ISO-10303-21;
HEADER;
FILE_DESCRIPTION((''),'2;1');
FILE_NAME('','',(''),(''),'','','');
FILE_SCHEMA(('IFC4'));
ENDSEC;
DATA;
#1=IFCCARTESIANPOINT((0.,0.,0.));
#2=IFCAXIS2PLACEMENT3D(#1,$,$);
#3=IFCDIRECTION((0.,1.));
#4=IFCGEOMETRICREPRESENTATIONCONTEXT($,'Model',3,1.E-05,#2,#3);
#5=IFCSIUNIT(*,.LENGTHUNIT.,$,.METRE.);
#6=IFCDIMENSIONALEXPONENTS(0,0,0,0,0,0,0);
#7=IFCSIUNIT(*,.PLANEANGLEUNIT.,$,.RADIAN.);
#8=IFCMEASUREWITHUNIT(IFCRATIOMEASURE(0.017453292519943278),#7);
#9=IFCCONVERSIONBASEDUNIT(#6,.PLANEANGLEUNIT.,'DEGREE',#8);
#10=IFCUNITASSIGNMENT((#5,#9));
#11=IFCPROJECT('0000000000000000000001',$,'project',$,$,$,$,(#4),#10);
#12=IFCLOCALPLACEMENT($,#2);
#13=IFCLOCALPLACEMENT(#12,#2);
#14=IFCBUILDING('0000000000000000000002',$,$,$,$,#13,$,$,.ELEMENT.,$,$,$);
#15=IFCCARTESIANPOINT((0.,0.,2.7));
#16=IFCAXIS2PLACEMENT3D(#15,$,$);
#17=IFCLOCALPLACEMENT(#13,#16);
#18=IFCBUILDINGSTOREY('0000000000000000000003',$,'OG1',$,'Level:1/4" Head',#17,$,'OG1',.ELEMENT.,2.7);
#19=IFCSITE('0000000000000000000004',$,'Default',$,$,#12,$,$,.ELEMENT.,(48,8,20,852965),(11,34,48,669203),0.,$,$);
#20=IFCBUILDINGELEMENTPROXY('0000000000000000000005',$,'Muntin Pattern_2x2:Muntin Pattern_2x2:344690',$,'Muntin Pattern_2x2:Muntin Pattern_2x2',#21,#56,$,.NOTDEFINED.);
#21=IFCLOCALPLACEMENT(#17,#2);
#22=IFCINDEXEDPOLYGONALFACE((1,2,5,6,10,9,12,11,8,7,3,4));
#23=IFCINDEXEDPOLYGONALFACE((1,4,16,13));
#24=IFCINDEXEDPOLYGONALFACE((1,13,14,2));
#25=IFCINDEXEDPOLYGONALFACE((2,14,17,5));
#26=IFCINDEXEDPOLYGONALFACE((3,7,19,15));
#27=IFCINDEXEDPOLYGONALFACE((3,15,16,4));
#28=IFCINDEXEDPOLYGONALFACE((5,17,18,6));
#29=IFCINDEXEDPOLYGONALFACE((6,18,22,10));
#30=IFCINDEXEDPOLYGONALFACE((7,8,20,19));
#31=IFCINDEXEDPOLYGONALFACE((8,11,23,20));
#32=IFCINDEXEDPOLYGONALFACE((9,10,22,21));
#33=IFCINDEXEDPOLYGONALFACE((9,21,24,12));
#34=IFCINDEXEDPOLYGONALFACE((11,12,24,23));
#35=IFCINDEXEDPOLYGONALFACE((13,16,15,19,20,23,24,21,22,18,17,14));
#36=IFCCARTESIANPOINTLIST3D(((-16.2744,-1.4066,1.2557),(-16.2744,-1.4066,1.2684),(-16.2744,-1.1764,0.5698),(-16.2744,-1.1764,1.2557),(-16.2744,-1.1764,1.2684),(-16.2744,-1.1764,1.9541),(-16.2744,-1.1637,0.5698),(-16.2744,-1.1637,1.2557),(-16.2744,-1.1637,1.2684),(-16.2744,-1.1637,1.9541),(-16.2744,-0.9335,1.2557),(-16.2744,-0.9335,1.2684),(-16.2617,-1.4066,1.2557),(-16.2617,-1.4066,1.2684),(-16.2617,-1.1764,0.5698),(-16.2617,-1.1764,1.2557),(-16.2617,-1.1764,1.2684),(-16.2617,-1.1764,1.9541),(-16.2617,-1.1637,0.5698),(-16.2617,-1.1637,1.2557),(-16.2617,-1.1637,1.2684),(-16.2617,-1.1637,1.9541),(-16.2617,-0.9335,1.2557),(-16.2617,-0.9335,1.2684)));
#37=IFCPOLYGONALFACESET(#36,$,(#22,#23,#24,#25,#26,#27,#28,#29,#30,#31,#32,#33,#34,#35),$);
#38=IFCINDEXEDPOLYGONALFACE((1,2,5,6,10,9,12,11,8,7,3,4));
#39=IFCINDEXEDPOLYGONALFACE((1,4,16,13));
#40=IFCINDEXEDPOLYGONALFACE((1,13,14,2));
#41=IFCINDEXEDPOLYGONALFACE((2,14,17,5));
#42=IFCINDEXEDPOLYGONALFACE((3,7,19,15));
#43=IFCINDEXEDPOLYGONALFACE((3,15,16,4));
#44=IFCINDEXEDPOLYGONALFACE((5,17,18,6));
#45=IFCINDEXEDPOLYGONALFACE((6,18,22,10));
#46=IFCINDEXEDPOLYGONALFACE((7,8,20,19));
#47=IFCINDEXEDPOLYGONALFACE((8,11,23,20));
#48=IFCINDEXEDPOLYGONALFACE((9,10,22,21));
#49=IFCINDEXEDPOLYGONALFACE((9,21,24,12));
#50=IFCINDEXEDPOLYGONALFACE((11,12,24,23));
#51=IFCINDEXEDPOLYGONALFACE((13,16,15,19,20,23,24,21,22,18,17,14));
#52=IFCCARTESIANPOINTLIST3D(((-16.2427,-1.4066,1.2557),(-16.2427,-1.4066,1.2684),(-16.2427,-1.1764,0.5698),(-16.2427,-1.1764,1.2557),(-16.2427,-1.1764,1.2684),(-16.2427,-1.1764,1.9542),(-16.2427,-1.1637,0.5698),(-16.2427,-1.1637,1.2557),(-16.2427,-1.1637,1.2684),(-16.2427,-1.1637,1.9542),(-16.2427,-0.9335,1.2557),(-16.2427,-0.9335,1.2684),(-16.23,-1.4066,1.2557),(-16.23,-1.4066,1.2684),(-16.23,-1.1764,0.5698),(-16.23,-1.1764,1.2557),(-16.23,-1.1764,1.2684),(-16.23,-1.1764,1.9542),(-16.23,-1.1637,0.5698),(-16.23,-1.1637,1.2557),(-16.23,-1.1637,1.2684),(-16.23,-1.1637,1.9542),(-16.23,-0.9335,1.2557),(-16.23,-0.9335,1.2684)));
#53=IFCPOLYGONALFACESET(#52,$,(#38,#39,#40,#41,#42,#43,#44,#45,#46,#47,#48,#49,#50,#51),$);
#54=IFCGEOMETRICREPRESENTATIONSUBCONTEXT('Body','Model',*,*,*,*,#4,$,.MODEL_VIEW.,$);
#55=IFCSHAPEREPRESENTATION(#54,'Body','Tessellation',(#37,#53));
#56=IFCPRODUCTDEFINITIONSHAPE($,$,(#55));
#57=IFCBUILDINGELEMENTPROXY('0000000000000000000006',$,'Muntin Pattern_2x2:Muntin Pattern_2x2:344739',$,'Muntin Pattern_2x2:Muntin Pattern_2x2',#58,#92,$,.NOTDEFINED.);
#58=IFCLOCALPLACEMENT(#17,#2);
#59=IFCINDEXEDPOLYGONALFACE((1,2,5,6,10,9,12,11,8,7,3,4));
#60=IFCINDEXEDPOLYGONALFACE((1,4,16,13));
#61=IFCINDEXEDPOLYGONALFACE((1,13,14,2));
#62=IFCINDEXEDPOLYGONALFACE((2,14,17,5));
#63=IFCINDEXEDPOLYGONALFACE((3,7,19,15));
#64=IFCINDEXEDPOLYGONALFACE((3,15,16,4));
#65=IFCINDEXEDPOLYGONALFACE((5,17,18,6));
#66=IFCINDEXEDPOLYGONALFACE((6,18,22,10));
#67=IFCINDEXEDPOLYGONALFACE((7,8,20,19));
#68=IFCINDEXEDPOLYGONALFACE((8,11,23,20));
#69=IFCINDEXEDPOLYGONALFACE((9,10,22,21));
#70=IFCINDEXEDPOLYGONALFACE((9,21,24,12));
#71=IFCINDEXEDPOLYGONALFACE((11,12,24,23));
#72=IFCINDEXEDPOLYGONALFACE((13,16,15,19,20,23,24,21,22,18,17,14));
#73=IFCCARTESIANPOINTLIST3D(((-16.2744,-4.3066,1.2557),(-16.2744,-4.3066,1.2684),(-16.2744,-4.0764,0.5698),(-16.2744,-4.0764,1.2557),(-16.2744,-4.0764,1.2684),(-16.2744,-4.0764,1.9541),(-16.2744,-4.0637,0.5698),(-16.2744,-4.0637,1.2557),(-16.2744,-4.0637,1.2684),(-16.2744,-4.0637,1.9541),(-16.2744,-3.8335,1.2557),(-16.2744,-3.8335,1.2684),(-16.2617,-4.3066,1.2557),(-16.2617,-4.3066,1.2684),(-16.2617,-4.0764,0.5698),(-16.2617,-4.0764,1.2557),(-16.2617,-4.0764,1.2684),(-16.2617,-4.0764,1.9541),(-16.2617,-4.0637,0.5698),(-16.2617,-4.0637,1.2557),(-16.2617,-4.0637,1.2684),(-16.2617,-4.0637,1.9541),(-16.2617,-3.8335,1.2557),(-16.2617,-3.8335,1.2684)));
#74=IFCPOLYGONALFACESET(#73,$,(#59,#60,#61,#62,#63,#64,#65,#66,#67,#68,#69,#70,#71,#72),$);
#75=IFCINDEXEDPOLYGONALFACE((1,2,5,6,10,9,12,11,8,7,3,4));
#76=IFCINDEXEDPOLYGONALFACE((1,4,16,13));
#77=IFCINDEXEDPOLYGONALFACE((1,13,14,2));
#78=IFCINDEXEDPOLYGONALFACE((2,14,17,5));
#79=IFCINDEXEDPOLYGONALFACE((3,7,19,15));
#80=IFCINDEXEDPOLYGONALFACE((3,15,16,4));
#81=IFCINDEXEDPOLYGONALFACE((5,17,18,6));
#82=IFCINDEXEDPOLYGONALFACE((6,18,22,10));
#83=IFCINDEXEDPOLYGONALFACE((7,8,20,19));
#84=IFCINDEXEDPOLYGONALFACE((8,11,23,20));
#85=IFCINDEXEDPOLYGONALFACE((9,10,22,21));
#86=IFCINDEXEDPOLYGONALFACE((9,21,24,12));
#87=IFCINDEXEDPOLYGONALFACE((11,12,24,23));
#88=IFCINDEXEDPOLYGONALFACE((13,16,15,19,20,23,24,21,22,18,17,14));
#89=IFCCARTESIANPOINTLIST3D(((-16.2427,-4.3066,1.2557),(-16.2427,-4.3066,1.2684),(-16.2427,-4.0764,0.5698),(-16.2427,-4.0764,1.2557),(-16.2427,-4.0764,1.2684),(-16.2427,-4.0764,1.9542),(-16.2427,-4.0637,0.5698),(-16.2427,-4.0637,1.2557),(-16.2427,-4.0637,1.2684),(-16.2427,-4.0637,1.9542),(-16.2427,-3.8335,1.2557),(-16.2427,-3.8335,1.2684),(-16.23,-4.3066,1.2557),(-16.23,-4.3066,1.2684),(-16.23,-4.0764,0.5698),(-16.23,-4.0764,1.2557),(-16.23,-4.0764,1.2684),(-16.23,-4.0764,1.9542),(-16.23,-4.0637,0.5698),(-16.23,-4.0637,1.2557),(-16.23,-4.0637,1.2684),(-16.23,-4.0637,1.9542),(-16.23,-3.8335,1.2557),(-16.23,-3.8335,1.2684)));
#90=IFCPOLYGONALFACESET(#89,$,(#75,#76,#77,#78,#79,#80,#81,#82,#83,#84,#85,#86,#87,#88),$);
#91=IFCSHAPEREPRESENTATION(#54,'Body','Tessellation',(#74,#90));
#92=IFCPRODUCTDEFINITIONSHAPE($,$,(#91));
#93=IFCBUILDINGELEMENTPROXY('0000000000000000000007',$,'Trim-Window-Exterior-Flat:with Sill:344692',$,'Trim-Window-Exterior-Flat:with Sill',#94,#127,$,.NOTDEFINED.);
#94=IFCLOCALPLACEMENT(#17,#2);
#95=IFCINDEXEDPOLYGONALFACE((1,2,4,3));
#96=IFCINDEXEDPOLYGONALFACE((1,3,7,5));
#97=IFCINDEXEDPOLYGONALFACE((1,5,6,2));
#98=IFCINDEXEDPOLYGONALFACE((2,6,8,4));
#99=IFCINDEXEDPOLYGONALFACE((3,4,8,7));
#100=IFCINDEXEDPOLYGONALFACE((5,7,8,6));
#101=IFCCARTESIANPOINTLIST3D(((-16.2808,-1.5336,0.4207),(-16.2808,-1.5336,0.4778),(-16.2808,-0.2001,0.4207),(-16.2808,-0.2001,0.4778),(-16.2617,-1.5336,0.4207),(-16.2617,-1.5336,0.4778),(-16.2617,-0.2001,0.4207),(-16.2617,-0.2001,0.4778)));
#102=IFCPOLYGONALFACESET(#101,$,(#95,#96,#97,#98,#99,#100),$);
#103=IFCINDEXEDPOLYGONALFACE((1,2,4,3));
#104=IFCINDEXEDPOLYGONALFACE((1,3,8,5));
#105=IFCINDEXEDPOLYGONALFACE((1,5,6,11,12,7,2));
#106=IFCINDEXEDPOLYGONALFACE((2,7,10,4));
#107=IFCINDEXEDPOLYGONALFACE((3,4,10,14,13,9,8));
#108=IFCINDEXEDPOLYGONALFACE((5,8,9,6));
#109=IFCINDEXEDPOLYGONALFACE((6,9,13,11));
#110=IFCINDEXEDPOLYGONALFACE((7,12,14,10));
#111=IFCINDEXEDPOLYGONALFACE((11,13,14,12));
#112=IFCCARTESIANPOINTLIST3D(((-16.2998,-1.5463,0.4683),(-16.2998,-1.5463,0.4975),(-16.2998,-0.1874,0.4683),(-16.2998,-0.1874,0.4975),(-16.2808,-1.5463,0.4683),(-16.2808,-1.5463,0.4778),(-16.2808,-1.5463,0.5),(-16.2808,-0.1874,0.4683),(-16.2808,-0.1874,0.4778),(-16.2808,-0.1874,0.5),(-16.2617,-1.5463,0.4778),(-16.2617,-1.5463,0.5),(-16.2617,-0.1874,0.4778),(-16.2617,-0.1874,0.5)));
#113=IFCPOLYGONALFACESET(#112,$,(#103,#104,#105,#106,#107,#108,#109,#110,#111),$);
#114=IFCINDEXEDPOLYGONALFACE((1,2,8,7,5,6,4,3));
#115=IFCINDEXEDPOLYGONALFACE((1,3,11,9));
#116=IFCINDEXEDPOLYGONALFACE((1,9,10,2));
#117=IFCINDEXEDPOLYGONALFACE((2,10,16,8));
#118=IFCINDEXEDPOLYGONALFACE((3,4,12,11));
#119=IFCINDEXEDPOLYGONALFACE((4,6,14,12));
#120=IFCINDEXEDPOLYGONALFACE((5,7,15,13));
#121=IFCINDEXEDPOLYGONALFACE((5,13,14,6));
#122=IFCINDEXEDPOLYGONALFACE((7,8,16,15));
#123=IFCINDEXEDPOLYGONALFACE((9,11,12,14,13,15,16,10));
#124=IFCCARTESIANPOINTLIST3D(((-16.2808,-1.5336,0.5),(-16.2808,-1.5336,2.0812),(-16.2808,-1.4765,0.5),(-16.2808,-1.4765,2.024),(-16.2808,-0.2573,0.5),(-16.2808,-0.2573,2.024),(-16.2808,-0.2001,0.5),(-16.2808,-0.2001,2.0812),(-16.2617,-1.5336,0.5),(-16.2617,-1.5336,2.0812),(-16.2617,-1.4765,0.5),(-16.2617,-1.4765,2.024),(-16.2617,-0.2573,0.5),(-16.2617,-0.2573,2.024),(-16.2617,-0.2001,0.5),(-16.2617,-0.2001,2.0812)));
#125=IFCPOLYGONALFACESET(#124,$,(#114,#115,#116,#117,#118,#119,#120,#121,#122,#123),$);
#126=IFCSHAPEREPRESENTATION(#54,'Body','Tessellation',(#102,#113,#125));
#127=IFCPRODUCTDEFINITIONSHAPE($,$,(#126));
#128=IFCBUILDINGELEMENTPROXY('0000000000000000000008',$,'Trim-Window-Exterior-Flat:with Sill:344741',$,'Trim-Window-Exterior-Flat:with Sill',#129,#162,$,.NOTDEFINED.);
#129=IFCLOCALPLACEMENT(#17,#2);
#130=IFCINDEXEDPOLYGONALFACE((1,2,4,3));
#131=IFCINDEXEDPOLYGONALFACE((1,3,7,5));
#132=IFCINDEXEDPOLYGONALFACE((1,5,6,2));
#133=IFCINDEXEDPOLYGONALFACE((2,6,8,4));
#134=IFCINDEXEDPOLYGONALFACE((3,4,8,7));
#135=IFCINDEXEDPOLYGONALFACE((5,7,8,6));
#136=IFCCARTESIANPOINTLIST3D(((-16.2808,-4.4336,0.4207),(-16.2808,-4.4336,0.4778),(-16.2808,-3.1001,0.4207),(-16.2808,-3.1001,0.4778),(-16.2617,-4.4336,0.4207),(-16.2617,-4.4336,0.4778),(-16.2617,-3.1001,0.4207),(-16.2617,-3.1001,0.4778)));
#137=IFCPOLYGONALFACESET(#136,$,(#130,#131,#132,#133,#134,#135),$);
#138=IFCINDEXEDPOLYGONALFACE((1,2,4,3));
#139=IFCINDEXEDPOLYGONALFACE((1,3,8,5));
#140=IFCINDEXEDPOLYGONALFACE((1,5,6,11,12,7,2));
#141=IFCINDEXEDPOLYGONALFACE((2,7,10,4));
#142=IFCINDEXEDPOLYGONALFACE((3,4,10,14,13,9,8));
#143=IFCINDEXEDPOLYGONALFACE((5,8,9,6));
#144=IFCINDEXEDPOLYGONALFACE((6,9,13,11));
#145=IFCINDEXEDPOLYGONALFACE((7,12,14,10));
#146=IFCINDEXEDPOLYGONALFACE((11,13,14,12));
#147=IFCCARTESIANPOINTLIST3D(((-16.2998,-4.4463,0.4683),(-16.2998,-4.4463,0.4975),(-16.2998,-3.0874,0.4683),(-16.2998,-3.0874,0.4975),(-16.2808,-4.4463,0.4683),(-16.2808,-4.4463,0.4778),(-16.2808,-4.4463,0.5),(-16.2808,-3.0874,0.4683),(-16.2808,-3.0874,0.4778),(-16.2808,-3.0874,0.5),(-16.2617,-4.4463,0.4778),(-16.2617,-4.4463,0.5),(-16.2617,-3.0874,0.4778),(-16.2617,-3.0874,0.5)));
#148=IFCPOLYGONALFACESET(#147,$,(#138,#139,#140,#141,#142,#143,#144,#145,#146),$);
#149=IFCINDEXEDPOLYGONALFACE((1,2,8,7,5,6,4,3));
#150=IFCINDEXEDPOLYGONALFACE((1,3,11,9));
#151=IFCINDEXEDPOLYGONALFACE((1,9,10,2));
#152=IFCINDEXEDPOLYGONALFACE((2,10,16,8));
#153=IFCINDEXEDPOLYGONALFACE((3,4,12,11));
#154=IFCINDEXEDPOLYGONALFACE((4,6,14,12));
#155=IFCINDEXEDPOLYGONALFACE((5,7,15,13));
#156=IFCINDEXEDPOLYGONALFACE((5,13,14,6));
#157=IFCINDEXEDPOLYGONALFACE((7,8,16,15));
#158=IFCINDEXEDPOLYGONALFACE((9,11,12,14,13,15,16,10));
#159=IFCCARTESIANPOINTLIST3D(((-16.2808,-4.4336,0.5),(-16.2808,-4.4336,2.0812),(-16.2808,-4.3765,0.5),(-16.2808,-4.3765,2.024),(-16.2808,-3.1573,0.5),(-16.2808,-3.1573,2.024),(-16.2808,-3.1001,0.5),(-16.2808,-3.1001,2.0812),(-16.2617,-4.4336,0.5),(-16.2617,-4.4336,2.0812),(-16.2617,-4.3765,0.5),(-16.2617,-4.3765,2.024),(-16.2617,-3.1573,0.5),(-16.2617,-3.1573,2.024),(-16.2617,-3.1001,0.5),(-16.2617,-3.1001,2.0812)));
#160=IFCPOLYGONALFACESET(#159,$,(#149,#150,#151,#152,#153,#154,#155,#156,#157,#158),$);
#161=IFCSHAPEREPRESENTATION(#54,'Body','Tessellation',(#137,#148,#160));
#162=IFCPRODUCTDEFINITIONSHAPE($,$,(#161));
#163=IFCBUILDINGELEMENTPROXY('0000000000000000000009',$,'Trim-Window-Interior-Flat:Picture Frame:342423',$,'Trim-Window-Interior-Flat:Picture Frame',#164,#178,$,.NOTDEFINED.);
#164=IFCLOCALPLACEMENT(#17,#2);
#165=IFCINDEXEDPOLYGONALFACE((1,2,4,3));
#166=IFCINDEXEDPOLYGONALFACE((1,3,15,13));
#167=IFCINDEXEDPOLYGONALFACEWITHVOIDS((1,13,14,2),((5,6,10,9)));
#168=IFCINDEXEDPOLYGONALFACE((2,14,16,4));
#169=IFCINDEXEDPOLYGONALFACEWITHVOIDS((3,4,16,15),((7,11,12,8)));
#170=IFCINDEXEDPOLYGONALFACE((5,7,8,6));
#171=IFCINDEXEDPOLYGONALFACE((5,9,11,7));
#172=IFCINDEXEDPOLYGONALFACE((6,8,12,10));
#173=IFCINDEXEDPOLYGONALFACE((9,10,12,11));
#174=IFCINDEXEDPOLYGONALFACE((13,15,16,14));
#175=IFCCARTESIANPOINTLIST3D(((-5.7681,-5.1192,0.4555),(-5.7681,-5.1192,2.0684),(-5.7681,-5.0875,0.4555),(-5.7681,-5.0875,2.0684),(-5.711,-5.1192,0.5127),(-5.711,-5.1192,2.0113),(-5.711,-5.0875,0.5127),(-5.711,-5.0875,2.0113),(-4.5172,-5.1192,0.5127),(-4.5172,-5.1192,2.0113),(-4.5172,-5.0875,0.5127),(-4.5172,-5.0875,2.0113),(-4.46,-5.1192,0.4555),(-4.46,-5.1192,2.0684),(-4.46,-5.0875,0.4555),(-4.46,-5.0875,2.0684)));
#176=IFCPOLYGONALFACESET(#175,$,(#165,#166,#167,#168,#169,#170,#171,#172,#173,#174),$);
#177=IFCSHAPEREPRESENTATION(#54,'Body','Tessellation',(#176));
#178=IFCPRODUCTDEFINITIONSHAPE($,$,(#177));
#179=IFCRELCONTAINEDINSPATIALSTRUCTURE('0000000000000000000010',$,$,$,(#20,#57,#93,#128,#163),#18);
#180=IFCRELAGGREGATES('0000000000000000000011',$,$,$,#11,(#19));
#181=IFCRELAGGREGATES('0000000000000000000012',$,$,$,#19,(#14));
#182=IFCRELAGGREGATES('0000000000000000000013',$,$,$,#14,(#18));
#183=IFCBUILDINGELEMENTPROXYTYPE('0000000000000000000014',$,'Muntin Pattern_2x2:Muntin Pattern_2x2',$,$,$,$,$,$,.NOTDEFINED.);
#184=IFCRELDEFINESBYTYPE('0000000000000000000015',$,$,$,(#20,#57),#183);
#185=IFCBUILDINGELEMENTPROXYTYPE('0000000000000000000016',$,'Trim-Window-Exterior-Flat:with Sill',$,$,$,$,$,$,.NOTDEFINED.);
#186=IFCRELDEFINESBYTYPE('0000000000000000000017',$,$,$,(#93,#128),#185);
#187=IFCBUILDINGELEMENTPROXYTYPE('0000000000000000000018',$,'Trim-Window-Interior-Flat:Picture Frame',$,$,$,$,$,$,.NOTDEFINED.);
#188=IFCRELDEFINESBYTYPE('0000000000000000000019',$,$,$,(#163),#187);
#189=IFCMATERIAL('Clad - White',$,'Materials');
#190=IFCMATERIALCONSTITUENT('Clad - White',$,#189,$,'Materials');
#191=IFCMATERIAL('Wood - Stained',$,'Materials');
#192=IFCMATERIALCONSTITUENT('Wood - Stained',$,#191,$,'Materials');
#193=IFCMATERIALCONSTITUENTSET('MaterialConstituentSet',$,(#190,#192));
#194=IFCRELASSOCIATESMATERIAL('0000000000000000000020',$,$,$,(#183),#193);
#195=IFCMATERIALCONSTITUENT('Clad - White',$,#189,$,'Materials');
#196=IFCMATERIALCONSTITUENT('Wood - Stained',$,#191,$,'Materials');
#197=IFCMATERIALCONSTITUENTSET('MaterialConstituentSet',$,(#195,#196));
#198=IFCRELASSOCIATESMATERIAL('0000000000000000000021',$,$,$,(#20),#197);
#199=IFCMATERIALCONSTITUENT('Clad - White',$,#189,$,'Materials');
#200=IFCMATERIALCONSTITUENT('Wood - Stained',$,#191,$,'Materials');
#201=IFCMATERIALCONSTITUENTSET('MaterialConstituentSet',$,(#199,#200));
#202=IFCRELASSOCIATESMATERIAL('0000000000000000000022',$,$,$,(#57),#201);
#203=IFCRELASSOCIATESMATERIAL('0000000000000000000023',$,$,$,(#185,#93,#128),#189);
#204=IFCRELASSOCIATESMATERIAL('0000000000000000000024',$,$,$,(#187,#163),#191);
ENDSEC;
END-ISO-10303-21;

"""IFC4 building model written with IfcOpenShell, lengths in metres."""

from ifc_helpers import new_model, entity, si_unit, converted_unit, direction, frame, origin, place, context, subcontext, project, spatial, indexed_curve, outline, extrude, source, transform, mapped, material, constituent, constituent_set, type_object, type_shapes, element, save


model = new_model("IFC4")

# Units and contexts
model_context = context("Model", 3, precision=1e-05, world=origin(), true_north=direction((0.0, 1.0)))
body_context = subcontext(model_context, "Body", "Model", "MODEL_VIEW")
ifc_project = project(units=[si_unit("LENGTHUNIT", "METRE"), converted_unit("PLANEANGLEUNIT", "DEGREE", entity("IfcRatioMeasure", 0.017453292519943278), si_unit("PLANEANGLEUNIT", "RADIAN"), dimensions=[0, 0, 0, 0, 0, 0, 0])], contexts=[model_context])

# Site, building, storey
site_placement = place(None, origin())
site = spatial("IfcSite", under=ifc_project, at=site_placement, Name="Default", CompositionType="ELEMENT", RefLatitude=(48, 8, 20, 852965), RefLongitude=(11, 34, 48, 669203), RefElevation=0.0)
building_placement = place(site_placement, origin())
building = spatial("IfcBuilding", under=site, at=building_placement, CompositionType="ELEMENT")
storey_placement = place(building_placement, frame((0.0, 0.0, 2.7)))
storey = spatial("IfcBuildingStorey", under=building, at=storey_placement, Name="OG1", ObjectType="Level:1/4\" Head", LongName="OG1", CompositionType="ELEMENT", Elevation=2.7)

# Building element proxies
ifc_material_1 = material(Name="Clad - White", Category="Materials")
ifc_material_2 = material(Name="Wood - Stained", Category="Materials")
ifc_constituent_1 = constituent(ifc_material_1, Name="Clad - White", Category="Materials")
ifc_constituent_2 = constituent(ifc_material_2, Name="Wood - Stained", Category="Materials")
ifc_constituent_set_1 = constituent_set(constituents=[ifc_constituent_1, ifc_constituent_2], Name="MaterialConstituentSet")
building_element_proxy_type_1 = type_object("IfcBuildingElementProxyType", Name="Muntin Pattern_2x2:Muntin Pattern_2x2", PredefinedType="NOTDEFINED", material=ifc_constituent_set_1)
shared_shape_1 = source(origin(), body_context, "Body", "SweptSolid", [
    extrude(outline(indexed_curve([(0.0064, -0.0064), (0.6921, -0.0064), (0.6921, 0.0063), (0.0064, 0.0063), (0.0064, 0.2365), (-0.0063, 0.2365), (-0.0063, 0.0063), (-0.6922, 0.0063), (-0.6922, -0.0064), (-0.0063, -0.0064), (-0.0063, -0.2365), (0.0064, -0.2365), (0.0064, -0.0064)], self_intersect=False)), frame((0.0, 0.0095, 0.6921), z_axis=(0.0, 1.0, 0.0), x_axis=(0.0, 0.0, 1.0)), (0.0, 0.0, 1.0), 0.0127),
    extrude(outline(indexed_curve([(0.0064, -0.0064), (0.6922, -0.0064), (0.6922, 0.0063), (0.0064, 0.0063), (0.0064, 0.2365), (-0.0063, 0.2365), (-0.0063, 0.0063), (-0.6922, 0.0063), (-0.6922, -0.0064), (-0.0063, -0.0064), (-0.0063, -0.2365), (0.0064, -0.2365), (0.0064, -0.0064)], self_intersect=False)), frame((0.0, -0.0222, 0.6922), z_axis=(0.0, 1.0, 0.0), x_axis=(0.0, 0.0, 1.0)), (0.0, 0.0, 1.0), 0.0127),
])
type_shapes(building_element_proxy_type_1, [shared_shape_1])
ifc_constituent_3 = constituent(ifc_material_1, Name="Clad - White", Category="Materials")
ifc_constituent_4 = constituent(ifc_material_2, Name="Wood - Stained", Category="Materials")
ifc_constituent_set_2 = constituent_set(constituents=[ifc_constituent_3, ifc_constituent_4], Name="MaterialConstituentSet")
proxy_1_placement = place(storey_placement, frame((-16.2522, -1.1701, 0.5699), z_axis=(0.0, 0.0, 1.0), x_axis=(0.0, 1.0, 0.0)))
element("IfcBuildingElementProxy", 1, at=proxy_1_placement, inside=storey, type_object=building_element_proxy_type_1, material=ifc_constituent_set_2, Name="Muntin Pattern_2x2:Muntin Pattern_2x2:344690", ObjectType="Muntin Pattern_2x2:Muntin Pattern_2x2", PredefinedType="NOTDEFINED", context=body_context, shape_type="MappedRepresentation", body=[
    mapped(shared_shape_1, transform((0.0, 0.0, 0.0), scale=1.0)),
])
ifc_constituent_5 = constituent(ifc_material_1, Name="Clad - White", Category="Materials")
ifc_constituent_6 = constituent(ifc_material_2, Name="Wood - Stained", Category="Materials")
ifc_constituent_set_3 = constituent_set(constituents=[ifc_constituent_5, ifc_constituent_6], Name="MaterialConstituentSet")
proxy_2_placement = place(storey_placement, frame((-16.2522, -4.0701, 0.5699), z_axis=(0.0, 0.0, 1.0), x_axis=(0.0, 1.0, 0.0)))
element("IfcBuildingElementProxy", 2, at=proxy_2_placement, inside=storey, type_object=building_element_proxy_type_1, material=ifc_constituent_set_3, Name="Muntin Pattern_2x2:Muntin Pattern_2x2:344739", ObjectType="Muntin Pattern_2x2:Muntin Pattern_2x2", PredefinedType="NOTDEFINED", context=body_context, shape_type="MappedRepresentation", body=[
    mapped(shared_shape_1, transform((0.0, 0.0, 0.0), scale=1.0)),
])
building_element_proxy_type_2 = type_object("IfcBuildingElementProxyType", Name="Trim-Window-Exterior-Flat:with Sill", PredefinedType="NOTDEFINED", material=ifc_material_1)
shared_shape_2 = source(origin(), body_context, "Body", "SweptSolid", [
    extrude(outline(indexed_curve([(-0.6667, -0.0286), (0.6667, -0.0286), (0.6667, 0.0286), (-0.6667, 0.0286), (-0.6667, -0.0286)], self_intersect=False)), frame((0.0, -1.5748, 0.0), z_axis=(0.0, 0.0, 1.0), x_axis=(-1.0, 0.0, 0.0)), (0.0, 0.0, 1.0), 0.019),
    extrude(outline(indexed_curve([(-0.019, -0.016), (0.0, -0.016), (0.0, -0.0064), (0.019, -0.0064), (0.019, 0.0158), (0.0, 0.0158), (-0.019, 0.0133), (-0.019, -0.016)], self_intersect=False)), frame((-0.6794, -1.5398, 0.019), z_axis=(1.0, 0.0, 0.0), x_axis=(0.0, 0.0, -1.0)), (0.0, 0.0, 1.0), 1.3589),
    extrude(outline(indexed_curve([(-0.8049, -0.6667), (0.7763, -0.6667), (0.7763, -0.6096), (-0.7477, -0.6096), (-0.7477, 0.6096), (0.7763, 0.6096), (0.7763, 0.6667), (-0.8049, 0.6667), (-0.8049, -0.6667)], self_intersect=False)), frame((0.0, -0.7477, 0.0), z_axis=(0.0, 0.0, 1.0), x_axis=(0.0, -1.0, 0.0)), (0.0, 0.0, 1.0), 0.019),
])
type_shapes(building_element_proxy_type_2, [shared_shape_2])
for number, where, z_axis, x_axis, name in (
    (3, (-16.2617, -0.8669, 2.024), (-1.0, 0.0, 0.0), (0.0, -1.0, 0.0), "Trim-Window-Exterior-Flat:with Sill:344692"),
    (4, (-16.2617, -3.7669, 2.024), (-1.0, 0.0, 0.0), (0.0, -1.0, 0.0), "Trim-Window-Exterior-Flat:with Sill:344741"),
):
    element("IfcBuildingElementProxy", number, at=place(storey_placement, frame(where, z_axis=z_axis, x_axis=x_axis)), inside=storey, type_object=building_element_proxy_type_2, material=ifc_material_1, Name=name, ObjectType="Trim-Window-Exterior-Flat:with Sill", PredefinedType="NOTDEFINED", context=body_context, shape_type="MappedRepresentation", body=[
        mapped(shared_shape_2, transform((0.0, 0.0, 0.0), scale=1.0)),
    ])
building_element_proxy_type_3 = type_object("IfcBuildingElementProxyType", Name="Trim-Window-Interior-Flat:Picture Frame", PredefinedType="NOTDEFINED", material=ifc_material_2)
shared_shape_3 = source(origin(), body_context, "Body", "SweptSolid", [
    extrude(outline(indexed_curve([(-0.654, -0.8064), (0.654, -0.8064), (0.654, 0.8064), (-0.654, 0.8064), (-0.654, -0.8064)], self_intersect=False), holes=[indexed_curve([(-0.5969, -0.7493), (-0.5969, 0.7493), (0.5969, 0.7493), (0.5969, -0.7493), (-0.5969, -0.7493)], self_intersect=False)]), frame((0.0, -0.762, 0.0), z_axis=(0.0, 0.0, 1.0), x_axis=(-1.0, 0.0, 0.0)), (0.0, 0.0, 1.0), 0.0317),
])
type_shapes(building_element_proxy_type_3, [shared_shape_3])
for number, where, z_axis, x_axis, name in (
    (5, (-5.1141, -5.1192, 2.024), (0.0, 1.0, 0.0), (-1.0, 0.0, 0.0), "Trim-Window-Interior-Flat:Picture Frame:342423"),
):
    element("IfcBuildingElementProxy", number, at=place(storey_placement, frame(where, z_axis=z_axis, x_axis=x_axis)), inside=storey, type_object=building_element_proxy_type_3, material=ifc_material_2, Name=name, ObjectType="Trim-Window-Interior-Flat:Picture Frame", PredefinedType="NOTDEFINED", context=body_context, shape_type="MappedRepresentation", body=[
        mapped(shared_shape_3, transform((0.0, 0.0, 0.0), scale=1.0)),
    ])

save(model, "model.ifc")
